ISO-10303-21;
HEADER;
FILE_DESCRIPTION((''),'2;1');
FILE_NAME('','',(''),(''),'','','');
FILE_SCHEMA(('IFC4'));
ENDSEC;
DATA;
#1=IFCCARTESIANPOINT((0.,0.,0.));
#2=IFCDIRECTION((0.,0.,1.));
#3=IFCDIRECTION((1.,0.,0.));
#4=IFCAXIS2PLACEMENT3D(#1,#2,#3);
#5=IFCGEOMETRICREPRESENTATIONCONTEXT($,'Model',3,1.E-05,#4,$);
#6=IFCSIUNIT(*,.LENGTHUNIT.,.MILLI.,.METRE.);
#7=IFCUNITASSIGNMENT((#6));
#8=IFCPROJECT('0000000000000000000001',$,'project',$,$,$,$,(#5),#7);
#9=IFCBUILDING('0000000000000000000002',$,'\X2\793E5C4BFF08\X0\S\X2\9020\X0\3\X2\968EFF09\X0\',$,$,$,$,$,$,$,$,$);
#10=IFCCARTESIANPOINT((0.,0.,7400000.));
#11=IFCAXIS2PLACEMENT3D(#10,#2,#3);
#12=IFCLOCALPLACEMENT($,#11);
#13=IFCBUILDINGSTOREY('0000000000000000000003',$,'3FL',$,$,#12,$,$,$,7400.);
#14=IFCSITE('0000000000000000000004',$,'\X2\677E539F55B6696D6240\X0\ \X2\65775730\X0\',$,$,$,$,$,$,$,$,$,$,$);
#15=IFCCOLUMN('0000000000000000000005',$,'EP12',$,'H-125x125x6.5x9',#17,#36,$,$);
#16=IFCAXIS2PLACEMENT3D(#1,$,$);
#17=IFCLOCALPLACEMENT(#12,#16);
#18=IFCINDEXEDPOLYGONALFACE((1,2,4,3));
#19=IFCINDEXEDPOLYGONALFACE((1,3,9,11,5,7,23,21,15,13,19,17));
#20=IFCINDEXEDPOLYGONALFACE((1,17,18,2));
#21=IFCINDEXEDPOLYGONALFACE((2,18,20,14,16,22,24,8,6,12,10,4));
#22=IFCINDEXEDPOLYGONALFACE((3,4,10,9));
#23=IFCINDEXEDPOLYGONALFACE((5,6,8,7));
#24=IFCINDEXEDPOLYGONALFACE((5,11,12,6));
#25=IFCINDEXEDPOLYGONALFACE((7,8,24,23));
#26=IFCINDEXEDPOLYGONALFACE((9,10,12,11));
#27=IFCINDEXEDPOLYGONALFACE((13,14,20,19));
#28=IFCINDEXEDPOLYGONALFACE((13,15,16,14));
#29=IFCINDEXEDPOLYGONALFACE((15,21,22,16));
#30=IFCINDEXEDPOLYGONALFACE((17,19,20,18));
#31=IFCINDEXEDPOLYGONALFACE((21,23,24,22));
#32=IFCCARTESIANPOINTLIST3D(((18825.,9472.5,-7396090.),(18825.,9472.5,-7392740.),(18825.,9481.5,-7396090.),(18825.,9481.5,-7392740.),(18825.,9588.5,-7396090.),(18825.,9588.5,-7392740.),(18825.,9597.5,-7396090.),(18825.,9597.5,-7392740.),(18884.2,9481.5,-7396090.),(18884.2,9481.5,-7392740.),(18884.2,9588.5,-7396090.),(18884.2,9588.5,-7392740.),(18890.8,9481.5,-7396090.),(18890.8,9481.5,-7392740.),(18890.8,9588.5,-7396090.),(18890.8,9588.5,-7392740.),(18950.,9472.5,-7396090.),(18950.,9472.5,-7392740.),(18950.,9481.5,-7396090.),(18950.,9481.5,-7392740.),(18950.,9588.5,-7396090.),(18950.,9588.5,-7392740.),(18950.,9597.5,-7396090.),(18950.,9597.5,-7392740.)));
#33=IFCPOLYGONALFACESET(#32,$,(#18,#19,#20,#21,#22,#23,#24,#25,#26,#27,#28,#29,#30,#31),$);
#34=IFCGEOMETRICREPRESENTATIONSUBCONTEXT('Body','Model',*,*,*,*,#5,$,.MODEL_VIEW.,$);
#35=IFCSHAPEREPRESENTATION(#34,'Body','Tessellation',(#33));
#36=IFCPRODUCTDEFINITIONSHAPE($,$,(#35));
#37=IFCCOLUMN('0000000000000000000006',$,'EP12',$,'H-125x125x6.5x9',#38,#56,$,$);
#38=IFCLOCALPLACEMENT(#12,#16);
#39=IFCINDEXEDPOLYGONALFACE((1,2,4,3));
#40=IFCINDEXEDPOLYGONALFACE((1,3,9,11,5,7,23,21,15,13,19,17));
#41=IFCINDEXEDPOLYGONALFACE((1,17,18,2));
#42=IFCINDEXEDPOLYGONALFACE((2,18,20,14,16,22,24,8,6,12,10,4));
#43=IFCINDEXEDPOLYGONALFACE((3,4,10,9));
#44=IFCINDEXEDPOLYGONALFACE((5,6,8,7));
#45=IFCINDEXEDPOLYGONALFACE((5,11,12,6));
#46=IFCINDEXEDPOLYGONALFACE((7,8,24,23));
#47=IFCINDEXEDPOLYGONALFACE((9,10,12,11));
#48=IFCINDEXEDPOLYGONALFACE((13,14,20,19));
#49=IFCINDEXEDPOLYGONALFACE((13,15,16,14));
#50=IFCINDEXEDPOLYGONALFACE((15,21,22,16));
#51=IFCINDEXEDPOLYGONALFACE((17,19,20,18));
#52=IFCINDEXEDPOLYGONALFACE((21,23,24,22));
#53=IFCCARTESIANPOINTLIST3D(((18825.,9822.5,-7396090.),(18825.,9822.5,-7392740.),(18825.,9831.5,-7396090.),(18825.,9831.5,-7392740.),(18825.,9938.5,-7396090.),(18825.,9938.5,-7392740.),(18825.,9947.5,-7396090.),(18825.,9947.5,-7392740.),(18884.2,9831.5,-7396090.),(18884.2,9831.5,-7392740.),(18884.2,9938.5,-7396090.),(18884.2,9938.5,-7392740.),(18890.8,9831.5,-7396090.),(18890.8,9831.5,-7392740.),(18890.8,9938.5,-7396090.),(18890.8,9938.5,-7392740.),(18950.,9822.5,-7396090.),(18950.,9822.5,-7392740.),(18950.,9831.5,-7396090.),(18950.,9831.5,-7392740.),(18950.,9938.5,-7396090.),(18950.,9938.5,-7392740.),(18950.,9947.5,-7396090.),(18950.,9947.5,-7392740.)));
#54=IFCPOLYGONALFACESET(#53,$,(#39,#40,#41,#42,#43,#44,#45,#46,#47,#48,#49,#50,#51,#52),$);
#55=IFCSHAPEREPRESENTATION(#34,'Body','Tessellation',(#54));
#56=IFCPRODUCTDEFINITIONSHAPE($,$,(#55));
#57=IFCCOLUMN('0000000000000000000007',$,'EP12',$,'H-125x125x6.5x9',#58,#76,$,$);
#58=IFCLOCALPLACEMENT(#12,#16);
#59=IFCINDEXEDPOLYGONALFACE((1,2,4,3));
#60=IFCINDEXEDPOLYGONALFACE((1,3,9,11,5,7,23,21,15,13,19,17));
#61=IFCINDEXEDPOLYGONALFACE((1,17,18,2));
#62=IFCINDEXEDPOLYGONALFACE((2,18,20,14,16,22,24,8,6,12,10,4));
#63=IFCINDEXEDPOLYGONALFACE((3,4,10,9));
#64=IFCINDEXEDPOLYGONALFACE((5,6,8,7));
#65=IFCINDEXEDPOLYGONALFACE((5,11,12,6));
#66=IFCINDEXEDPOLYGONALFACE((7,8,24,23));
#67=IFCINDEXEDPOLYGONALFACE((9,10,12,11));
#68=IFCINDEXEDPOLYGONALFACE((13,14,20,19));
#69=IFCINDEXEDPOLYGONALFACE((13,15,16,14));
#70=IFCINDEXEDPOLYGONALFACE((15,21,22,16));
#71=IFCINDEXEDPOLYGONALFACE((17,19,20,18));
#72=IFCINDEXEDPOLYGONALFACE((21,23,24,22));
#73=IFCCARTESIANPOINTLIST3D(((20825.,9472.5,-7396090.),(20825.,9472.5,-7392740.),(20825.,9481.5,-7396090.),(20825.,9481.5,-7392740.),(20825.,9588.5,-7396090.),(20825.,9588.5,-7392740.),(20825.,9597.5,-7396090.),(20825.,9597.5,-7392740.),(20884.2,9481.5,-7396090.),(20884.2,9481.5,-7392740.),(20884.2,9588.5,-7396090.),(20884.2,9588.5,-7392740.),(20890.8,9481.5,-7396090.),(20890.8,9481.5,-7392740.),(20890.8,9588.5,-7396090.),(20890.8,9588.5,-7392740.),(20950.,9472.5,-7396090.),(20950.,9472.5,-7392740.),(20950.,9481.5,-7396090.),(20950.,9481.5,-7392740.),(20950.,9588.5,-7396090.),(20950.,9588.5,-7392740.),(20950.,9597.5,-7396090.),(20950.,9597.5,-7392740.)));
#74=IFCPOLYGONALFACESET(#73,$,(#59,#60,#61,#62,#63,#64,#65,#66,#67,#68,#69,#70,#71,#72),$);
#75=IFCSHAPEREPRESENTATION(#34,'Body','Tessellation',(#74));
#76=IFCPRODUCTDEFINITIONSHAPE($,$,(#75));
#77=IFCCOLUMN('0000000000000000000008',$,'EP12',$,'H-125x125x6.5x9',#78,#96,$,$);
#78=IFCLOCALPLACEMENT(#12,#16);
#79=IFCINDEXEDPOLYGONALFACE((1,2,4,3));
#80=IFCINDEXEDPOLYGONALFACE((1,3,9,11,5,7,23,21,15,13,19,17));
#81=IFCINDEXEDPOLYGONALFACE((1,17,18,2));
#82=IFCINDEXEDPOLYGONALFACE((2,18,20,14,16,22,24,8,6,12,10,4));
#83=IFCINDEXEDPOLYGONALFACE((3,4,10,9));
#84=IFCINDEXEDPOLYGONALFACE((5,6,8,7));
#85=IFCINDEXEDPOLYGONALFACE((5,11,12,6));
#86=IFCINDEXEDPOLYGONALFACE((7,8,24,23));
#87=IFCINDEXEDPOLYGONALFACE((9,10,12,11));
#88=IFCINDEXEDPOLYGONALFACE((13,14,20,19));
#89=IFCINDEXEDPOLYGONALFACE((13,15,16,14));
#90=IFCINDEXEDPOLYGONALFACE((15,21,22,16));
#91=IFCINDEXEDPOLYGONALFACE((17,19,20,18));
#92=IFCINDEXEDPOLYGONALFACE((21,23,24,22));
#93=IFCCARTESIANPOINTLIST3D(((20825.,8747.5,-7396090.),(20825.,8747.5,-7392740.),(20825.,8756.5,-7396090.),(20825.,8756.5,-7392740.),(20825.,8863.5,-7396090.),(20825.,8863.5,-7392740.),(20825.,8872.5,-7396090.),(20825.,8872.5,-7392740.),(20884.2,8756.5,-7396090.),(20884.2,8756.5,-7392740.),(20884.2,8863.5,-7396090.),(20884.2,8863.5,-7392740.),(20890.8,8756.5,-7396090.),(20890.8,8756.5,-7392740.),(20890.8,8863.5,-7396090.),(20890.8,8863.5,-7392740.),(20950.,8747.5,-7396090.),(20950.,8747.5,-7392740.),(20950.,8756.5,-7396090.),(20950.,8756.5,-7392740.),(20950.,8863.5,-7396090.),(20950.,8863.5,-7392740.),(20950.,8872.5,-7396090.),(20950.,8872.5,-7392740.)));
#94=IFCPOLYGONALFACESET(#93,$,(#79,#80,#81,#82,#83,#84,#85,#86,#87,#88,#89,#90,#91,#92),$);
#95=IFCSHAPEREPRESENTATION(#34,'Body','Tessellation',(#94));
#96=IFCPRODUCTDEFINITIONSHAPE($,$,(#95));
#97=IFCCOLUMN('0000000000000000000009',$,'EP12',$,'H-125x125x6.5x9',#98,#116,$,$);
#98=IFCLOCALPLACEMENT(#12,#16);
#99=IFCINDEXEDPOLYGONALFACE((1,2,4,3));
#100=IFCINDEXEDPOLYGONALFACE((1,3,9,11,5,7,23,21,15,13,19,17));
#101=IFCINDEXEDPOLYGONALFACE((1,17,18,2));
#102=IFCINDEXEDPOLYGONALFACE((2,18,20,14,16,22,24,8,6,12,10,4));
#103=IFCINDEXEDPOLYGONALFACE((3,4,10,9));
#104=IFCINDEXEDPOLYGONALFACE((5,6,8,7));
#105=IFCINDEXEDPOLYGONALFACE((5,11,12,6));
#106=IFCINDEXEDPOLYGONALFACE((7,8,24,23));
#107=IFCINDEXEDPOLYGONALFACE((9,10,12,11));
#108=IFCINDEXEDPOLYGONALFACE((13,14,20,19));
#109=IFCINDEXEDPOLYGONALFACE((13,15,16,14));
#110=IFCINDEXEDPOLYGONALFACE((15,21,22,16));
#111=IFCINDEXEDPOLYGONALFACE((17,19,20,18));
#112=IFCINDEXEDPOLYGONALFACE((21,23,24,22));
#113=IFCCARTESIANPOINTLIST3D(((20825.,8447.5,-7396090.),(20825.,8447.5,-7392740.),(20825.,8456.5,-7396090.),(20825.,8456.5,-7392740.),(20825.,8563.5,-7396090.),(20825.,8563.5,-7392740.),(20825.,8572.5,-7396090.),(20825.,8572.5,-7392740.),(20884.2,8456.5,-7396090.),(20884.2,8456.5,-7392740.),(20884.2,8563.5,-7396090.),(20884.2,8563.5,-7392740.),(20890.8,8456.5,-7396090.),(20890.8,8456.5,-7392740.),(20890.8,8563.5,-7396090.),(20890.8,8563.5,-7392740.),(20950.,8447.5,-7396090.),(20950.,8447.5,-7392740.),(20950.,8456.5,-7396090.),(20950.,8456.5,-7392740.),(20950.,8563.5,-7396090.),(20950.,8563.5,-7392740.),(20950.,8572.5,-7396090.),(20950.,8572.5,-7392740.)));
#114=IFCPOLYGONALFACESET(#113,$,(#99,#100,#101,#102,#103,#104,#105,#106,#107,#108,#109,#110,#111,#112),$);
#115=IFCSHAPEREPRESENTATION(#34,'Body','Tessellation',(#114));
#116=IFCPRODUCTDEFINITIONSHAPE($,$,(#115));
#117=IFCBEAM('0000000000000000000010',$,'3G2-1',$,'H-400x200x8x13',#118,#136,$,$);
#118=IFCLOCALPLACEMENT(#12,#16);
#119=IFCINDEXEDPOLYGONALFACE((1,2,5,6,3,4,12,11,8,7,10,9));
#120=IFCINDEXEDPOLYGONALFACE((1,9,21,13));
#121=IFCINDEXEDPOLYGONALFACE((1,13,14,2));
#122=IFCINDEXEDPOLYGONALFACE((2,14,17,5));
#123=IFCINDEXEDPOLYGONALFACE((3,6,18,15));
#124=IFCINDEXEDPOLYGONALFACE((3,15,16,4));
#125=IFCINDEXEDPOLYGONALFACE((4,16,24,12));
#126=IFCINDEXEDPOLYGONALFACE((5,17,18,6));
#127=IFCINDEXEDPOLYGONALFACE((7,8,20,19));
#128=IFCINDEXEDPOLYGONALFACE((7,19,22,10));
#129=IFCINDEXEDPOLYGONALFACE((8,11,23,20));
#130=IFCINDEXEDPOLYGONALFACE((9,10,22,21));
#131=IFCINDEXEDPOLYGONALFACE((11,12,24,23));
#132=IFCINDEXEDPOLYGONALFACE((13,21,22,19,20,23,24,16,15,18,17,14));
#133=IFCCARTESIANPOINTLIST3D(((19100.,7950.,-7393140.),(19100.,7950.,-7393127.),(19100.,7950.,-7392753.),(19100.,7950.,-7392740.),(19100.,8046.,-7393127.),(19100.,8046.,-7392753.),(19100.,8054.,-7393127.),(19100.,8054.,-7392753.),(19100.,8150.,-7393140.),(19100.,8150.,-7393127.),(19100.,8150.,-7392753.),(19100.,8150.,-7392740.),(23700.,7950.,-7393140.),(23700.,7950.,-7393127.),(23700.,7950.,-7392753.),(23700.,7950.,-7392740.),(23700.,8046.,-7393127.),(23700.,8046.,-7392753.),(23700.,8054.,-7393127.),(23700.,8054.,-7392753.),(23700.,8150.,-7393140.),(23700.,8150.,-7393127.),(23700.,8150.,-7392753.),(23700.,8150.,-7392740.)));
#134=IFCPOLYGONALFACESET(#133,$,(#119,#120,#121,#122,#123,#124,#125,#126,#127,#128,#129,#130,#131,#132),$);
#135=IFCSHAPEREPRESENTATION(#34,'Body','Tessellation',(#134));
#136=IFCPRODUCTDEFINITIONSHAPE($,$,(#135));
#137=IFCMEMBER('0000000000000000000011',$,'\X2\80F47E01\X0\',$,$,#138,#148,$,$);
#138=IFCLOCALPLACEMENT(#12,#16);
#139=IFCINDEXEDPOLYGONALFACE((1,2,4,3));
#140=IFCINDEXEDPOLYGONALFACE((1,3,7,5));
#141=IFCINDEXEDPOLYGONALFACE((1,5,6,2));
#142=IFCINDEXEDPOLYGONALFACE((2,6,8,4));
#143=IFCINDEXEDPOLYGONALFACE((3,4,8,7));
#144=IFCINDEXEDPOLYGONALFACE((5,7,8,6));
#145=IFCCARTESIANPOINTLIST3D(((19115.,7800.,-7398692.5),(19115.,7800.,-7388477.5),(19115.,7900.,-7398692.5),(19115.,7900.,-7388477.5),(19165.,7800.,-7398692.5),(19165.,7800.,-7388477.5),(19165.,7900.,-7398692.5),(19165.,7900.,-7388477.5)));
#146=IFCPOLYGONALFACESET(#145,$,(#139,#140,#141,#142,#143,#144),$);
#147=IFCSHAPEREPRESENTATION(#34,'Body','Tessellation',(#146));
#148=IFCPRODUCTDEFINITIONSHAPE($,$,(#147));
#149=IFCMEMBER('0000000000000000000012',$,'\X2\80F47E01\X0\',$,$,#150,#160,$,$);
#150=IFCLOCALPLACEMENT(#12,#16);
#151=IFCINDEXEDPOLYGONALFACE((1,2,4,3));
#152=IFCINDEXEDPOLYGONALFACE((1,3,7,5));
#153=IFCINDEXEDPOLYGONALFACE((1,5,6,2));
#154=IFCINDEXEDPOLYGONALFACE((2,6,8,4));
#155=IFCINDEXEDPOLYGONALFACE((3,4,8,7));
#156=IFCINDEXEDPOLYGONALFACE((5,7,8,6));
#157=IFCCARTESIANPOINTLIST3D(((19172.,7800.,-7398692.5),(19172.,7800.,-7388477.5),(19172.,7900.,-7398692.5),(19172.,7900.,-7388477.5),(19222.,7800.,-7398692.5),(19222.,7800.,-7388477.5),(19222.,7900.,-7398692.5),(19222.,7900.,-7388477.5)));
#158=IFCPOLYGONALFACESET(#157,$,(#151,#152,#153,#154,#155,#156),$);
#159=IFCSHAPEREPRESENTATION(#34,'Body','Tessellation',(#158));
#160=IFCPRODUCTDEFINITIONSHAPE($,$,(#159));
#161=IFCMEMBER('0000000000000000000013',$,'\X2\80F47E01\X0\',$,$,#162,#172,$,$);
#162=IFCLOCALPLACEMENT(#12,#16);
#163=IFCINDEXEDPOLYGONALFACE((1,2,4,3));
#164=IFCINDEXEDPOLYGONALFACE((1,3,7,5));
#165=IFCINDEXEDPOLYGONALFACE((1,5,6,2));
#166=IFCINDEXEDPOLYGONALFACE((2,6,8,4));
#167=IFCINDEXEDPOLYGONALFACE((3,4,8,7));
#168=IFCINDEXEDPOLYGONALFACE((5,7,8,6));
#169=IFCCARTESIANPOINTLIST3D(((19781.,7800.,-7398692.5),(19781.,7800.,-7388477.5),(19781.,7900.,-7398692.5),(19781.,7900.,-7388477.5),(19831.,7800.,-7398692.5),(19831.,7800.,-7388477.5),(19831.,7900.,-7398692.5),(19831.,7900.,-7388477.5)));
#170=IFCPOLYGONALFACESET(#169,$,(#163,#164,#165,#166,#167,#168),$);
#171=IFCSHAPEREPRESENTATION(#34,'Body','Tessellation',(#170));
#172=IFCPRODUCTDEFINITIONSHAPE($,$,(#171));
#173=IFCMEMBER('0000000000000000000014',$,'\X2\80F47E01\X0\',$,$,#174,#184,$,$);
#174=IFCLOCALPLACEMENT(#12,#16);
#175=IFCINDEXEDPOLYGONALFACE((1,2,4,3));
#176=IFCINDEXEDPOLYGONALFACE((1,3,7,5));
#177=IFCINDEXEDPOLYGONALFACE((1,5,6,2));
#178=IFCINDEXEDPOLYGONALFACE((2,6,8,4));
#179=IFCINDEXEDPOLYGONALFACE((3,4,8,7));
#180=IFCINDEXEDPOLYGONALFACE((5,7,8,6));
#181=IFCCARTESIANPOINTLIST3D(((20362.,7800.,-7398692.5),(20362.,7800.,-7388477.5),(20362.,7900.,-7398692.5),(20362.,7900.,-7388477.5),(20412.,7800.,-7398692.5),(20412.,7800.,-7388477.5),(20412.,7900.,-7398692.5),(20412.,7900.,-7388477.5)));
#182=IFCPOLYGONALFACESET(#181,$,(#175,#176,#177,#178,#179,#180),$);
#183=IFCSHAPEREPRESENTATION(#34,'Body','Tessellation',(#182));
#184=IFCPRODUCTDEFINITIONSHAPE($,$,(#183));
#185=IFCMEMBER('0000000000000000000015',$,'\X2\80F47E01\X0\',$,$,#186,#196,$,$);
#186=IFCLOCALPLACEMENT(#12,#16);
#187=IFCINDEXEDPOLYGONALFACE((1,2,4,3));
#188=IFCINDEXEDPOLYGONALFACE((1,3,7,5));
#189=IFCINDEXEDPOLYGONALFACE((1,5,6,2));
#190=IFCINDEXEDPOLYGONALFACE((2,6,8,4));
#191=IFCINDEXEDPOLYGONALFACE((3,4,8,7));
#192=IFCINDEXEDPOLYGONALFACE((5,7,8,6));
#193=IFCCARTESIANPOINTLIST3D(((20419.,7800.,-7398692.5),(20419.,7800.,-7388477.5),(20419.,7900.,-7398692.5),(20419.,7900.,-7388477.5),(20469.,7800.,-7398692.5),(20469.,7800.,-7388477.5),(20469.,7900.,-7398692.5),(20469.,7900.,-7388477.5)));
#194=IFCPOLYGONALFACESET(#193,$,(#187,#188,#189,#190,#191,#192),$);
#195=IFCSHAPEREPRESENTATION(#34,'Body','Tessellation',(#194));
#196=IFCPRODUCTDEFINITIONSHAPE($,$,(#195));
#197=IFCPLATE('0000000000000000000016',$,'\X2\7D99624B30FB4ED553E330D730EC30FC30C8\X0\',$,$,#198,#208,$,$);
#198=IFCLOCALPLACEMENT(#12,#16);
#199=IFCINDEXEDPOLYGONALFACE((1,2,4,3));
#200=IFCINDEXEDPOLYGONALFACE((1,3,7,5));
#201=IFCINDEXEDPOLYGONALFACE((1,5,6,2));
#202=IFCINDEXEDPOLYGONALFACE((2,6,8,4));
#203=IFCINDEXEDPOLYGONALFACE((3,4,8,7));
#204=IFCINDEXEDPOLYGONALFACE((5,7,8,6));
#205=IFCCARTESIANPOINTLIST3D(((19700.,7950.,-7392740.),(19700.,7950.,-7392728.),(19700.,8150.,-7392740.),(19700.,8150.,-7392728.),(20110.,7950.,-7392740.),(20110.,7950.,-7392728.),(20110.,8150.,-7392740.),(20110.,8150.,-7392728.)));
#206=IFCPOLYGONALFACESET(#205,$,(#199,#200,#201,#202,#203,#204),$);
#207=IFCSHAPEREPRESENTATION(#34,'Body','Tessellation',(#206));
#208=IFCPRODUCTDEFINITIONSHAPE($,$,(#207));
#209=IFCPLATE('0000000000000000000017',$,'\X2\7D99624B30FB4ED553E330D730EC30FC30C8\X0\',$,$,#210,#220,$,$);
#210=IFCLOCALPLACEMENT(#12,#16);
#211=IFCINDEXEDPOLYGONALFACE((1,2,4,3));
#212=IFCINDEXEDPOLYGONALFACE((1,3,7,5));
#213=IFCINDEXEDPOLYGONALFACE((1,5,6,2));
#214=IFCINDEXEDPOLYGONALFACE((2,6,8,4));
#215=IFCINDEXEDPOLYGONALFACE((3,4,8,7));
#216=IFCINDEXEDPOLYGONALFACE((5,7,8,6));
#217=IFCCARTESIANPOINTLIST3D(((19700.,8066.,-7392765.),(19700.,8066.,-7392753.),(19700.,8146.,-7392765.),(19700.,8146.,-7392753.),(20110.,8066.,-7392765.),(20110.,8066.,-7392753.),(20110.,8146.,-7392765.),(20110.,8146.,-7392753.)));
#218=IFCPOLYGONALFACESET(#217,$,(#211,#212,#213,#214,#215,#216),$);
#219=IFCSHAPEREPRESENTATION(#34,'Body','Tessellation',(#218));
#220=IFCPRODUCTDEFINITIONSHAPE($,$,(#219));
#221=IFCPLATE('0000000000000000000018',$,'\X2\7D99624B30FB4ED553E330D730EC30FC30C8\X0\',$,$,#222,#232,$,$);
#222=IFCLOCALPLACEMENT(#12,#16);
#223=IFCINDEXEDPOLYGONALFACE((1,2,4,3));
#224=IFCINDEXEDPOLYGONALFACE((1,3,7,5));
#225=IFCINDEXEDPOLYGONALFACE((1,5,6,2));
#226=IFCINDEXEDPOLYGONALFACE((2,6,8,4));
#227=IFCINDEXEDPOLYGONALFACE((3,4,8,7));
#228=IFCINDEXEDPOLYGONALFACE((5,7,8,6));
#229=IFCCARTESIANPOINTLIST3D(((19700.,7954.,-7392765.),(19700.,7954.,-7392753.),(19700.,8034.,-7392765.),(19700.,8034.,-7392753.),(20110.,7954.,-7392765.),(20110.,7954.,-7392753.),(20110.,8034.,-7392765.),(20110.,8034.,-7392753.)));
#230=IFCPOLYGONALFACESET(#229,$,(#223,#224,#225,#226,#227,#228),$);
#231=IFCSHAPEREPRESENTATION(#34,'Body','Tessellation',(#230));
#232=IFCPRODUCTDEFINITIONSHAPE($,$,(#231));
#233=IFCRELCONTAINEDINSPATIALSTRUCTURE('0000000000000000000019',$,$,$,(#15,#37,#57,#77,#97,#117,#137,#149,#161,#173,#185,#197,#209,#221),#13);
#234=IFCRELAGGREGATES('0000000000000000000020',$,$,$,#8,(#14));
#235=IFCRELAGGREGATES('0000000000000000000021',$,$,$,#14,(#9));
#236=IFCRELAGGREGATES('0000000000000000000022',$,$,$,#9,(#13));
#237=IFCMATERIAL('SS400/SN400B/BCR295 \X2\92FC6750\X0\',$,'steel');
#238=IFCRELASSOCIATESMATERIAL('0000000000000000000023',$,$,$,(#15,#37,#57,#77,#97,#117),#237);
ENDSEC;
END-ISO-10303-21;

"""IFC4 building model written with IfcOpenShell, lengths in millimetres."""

from ifc_helpers import new_model, si_unit, frame, origin, origin_with_axes, place, context, subcontext, project, spatial, rectangle, i_section, extrude, material, element, save


model = new_model("IFC4")

# Units and contexts
model_context = context("Model", 3, precision=1e-05, world=origin_with_axes())
body_context = subcontext(model_context, "Body", "Model", "MODEL_VIEW")
ifc_project = project(units=[si_unit("LENGTHUNIT", "METRE", prefix="MILLI")], contexts=[model_context])

# Site, building, storey
site = spatial("IfcSite", under=ifc_project, Name="松原営業所 敷地")
building = spatial("IfcBuilding", under=site, Name="社屋（S造3階）")
storey_placement = place(None, frame((0.0, 0.0, 7400000.0), z_axis=(0.0, 0.0, 1.0), x_axis=(1.0, 0.0, 0.0)))
storey = spatial("IfcBuildingStorey", under=building, at=storey_placement, Name="3FL", Elevation=7400.0)

# Columns
ifc_material = material(Name="SS400/SN400B/BCR295 鋼材", Category="steel")
for number, where, z_axis, x_axis, name in (
    (1, (18887.5, 9535.0, -7396090.0), (0.0, 0.0, 1.0), (1.0, 0.0, 0.0), "EP12"),
    (2, (18887.5, 9885.0, -7396090.0), (0.0, 0.0, 1.0), (1.0, 0.0, 0.0), "EP12"),
    (3, (20887.5, 9535.0, -7396090.0), (0.0, 0.0, 1.0), (1.0, 0.0, 0.0), "EP12"),
    (4, (20887.5, 8810.0, -7396090.0), (0.0, 0.0, 1.0), (1.0, 0.0, 0.0), "EP12"),
    (5, (20887.5, 8510.0, -7396090.0), (0.0, 0.0, 1.0), (1.0, 0.0, 0.0), "EP12"),
):
    element("IfcColumn", number, at=place(storey_placement, frame(where, z_axis=z_axis, x_axis=x_axis)), inside=storey, material=ifc_material, Name=name, ObjectType="H-125x125x6.5x9", context=body_context, shape_type="SweptSolid", body=[
        extrude(i_section(OverallWidth=125.0, OverallDepth=125.0, WebThickness=6.5, FlangeThickness=9.0), origin(), (0.0, 0.0, 1.0), 3350.0),
    ])

# Beam
beam_placement = place(storey_placement, frame((19100.0, 8050.0, -7392740.0), z_axis=(1.0, 0.0, 0.0), x_axis=(0.0, 1.0, 0.0)))
element("IfcBeam", 6, at=beam_placement, inside=storey, material=ifc_material, Name="3G2-1", ObjectType="H-400x200x8x13", context=body_context, shape_type="SweptSolid", body=[
    extrude(i_section(OverallWidth=200.0, OverallDepth=400.0, WebThickness=8.0, FlangeThickness=13.0), frame((0.0, -200.0, 0.0)), (0.0, 0.0, 1.0), 4600.0),
])

# Members
for number, where, z_axis, x_axis, name in (
    (7, (19115.0, 7850.0, -7393585.0), (1.0, 0.0, 0.0), (0.0, 1.0, 0.0), "胴縁"),
    (8, (19172.0, 7850.0, -7393585.0), (1.0, 0.0, 0.0), (0.0, 1.0, 0.0), "胴縁"),
    (9, (19781.0, 7850.0, -7393585.0), (1.0, 0.0, 0.0), (0.0, 1.0, 0.0), "胴縁"),
    (10, (20362.0, 7850.0, -7393585.0), (1.0, 0.0, 0.0), (0.0, 1.0, 0.0), "胴縁"),
    (11, (20419.0, 7850.0, -7393585.0), (1.0, 0.0, 0.0), (0.0, 1.0, 0.0), "胴縁"),
):
    element("IfcMember", number, at=place(storey_placement, frame(where, z_axis=z_axis, x_axis=x_axis)), inside=storey, Name=name, context=body_context, shape_type="SweptSolid", body=[
        extrude(rectangle(XDim=100.0, YDim=10215.0), origin(), (0.0, 0.0, 1.0), 50.0),
    ])

# Plates
plate_1_placement = place(storey_placement, frame((19700.0, 8050.0, -7392734.0), z_axis=(1.0, 0.0, 0.0), x_axis=(0.0, 1.0, 0.0)))
element("IfcPlate", 12, at=plate_1_placement, inside=storey, Name="継手・仕口プレート", context=body_context, shape_type="SweptSolid", body=[
    extrude(rectangle(XDim=200.0, YDim=12.0), origin(), (0.0, 0.0, 1.0), 410.0),
])
for number, where, z_axis, x_axis, name in (
    (13, (19700.0, 8106.0, -7392759.0), (1.0, 0.0, 0.0), (0.0, 1.0, 0.0), "継手・仕口プレート"),
    (14, (19700.0, 7994.0, -7392759.0), (1.0, 0.0, 0.0), (0.0, 1.0, 0.0), "継手・仕口プレート"),
):
    element("IfcPlate", number, at=place(storey_placement, frame(where, z_axis=z_axis, x_axis=x_axis)), inside=storey, Name=name, context=body_context, shape_type="SweptSolid", body=[
        extrude(rectangle(XDim=80.0, YDim=12.0), origin(), (0.0, 0.0, 1.0), 410.0),
    ])

save(model, "model.ifc")
